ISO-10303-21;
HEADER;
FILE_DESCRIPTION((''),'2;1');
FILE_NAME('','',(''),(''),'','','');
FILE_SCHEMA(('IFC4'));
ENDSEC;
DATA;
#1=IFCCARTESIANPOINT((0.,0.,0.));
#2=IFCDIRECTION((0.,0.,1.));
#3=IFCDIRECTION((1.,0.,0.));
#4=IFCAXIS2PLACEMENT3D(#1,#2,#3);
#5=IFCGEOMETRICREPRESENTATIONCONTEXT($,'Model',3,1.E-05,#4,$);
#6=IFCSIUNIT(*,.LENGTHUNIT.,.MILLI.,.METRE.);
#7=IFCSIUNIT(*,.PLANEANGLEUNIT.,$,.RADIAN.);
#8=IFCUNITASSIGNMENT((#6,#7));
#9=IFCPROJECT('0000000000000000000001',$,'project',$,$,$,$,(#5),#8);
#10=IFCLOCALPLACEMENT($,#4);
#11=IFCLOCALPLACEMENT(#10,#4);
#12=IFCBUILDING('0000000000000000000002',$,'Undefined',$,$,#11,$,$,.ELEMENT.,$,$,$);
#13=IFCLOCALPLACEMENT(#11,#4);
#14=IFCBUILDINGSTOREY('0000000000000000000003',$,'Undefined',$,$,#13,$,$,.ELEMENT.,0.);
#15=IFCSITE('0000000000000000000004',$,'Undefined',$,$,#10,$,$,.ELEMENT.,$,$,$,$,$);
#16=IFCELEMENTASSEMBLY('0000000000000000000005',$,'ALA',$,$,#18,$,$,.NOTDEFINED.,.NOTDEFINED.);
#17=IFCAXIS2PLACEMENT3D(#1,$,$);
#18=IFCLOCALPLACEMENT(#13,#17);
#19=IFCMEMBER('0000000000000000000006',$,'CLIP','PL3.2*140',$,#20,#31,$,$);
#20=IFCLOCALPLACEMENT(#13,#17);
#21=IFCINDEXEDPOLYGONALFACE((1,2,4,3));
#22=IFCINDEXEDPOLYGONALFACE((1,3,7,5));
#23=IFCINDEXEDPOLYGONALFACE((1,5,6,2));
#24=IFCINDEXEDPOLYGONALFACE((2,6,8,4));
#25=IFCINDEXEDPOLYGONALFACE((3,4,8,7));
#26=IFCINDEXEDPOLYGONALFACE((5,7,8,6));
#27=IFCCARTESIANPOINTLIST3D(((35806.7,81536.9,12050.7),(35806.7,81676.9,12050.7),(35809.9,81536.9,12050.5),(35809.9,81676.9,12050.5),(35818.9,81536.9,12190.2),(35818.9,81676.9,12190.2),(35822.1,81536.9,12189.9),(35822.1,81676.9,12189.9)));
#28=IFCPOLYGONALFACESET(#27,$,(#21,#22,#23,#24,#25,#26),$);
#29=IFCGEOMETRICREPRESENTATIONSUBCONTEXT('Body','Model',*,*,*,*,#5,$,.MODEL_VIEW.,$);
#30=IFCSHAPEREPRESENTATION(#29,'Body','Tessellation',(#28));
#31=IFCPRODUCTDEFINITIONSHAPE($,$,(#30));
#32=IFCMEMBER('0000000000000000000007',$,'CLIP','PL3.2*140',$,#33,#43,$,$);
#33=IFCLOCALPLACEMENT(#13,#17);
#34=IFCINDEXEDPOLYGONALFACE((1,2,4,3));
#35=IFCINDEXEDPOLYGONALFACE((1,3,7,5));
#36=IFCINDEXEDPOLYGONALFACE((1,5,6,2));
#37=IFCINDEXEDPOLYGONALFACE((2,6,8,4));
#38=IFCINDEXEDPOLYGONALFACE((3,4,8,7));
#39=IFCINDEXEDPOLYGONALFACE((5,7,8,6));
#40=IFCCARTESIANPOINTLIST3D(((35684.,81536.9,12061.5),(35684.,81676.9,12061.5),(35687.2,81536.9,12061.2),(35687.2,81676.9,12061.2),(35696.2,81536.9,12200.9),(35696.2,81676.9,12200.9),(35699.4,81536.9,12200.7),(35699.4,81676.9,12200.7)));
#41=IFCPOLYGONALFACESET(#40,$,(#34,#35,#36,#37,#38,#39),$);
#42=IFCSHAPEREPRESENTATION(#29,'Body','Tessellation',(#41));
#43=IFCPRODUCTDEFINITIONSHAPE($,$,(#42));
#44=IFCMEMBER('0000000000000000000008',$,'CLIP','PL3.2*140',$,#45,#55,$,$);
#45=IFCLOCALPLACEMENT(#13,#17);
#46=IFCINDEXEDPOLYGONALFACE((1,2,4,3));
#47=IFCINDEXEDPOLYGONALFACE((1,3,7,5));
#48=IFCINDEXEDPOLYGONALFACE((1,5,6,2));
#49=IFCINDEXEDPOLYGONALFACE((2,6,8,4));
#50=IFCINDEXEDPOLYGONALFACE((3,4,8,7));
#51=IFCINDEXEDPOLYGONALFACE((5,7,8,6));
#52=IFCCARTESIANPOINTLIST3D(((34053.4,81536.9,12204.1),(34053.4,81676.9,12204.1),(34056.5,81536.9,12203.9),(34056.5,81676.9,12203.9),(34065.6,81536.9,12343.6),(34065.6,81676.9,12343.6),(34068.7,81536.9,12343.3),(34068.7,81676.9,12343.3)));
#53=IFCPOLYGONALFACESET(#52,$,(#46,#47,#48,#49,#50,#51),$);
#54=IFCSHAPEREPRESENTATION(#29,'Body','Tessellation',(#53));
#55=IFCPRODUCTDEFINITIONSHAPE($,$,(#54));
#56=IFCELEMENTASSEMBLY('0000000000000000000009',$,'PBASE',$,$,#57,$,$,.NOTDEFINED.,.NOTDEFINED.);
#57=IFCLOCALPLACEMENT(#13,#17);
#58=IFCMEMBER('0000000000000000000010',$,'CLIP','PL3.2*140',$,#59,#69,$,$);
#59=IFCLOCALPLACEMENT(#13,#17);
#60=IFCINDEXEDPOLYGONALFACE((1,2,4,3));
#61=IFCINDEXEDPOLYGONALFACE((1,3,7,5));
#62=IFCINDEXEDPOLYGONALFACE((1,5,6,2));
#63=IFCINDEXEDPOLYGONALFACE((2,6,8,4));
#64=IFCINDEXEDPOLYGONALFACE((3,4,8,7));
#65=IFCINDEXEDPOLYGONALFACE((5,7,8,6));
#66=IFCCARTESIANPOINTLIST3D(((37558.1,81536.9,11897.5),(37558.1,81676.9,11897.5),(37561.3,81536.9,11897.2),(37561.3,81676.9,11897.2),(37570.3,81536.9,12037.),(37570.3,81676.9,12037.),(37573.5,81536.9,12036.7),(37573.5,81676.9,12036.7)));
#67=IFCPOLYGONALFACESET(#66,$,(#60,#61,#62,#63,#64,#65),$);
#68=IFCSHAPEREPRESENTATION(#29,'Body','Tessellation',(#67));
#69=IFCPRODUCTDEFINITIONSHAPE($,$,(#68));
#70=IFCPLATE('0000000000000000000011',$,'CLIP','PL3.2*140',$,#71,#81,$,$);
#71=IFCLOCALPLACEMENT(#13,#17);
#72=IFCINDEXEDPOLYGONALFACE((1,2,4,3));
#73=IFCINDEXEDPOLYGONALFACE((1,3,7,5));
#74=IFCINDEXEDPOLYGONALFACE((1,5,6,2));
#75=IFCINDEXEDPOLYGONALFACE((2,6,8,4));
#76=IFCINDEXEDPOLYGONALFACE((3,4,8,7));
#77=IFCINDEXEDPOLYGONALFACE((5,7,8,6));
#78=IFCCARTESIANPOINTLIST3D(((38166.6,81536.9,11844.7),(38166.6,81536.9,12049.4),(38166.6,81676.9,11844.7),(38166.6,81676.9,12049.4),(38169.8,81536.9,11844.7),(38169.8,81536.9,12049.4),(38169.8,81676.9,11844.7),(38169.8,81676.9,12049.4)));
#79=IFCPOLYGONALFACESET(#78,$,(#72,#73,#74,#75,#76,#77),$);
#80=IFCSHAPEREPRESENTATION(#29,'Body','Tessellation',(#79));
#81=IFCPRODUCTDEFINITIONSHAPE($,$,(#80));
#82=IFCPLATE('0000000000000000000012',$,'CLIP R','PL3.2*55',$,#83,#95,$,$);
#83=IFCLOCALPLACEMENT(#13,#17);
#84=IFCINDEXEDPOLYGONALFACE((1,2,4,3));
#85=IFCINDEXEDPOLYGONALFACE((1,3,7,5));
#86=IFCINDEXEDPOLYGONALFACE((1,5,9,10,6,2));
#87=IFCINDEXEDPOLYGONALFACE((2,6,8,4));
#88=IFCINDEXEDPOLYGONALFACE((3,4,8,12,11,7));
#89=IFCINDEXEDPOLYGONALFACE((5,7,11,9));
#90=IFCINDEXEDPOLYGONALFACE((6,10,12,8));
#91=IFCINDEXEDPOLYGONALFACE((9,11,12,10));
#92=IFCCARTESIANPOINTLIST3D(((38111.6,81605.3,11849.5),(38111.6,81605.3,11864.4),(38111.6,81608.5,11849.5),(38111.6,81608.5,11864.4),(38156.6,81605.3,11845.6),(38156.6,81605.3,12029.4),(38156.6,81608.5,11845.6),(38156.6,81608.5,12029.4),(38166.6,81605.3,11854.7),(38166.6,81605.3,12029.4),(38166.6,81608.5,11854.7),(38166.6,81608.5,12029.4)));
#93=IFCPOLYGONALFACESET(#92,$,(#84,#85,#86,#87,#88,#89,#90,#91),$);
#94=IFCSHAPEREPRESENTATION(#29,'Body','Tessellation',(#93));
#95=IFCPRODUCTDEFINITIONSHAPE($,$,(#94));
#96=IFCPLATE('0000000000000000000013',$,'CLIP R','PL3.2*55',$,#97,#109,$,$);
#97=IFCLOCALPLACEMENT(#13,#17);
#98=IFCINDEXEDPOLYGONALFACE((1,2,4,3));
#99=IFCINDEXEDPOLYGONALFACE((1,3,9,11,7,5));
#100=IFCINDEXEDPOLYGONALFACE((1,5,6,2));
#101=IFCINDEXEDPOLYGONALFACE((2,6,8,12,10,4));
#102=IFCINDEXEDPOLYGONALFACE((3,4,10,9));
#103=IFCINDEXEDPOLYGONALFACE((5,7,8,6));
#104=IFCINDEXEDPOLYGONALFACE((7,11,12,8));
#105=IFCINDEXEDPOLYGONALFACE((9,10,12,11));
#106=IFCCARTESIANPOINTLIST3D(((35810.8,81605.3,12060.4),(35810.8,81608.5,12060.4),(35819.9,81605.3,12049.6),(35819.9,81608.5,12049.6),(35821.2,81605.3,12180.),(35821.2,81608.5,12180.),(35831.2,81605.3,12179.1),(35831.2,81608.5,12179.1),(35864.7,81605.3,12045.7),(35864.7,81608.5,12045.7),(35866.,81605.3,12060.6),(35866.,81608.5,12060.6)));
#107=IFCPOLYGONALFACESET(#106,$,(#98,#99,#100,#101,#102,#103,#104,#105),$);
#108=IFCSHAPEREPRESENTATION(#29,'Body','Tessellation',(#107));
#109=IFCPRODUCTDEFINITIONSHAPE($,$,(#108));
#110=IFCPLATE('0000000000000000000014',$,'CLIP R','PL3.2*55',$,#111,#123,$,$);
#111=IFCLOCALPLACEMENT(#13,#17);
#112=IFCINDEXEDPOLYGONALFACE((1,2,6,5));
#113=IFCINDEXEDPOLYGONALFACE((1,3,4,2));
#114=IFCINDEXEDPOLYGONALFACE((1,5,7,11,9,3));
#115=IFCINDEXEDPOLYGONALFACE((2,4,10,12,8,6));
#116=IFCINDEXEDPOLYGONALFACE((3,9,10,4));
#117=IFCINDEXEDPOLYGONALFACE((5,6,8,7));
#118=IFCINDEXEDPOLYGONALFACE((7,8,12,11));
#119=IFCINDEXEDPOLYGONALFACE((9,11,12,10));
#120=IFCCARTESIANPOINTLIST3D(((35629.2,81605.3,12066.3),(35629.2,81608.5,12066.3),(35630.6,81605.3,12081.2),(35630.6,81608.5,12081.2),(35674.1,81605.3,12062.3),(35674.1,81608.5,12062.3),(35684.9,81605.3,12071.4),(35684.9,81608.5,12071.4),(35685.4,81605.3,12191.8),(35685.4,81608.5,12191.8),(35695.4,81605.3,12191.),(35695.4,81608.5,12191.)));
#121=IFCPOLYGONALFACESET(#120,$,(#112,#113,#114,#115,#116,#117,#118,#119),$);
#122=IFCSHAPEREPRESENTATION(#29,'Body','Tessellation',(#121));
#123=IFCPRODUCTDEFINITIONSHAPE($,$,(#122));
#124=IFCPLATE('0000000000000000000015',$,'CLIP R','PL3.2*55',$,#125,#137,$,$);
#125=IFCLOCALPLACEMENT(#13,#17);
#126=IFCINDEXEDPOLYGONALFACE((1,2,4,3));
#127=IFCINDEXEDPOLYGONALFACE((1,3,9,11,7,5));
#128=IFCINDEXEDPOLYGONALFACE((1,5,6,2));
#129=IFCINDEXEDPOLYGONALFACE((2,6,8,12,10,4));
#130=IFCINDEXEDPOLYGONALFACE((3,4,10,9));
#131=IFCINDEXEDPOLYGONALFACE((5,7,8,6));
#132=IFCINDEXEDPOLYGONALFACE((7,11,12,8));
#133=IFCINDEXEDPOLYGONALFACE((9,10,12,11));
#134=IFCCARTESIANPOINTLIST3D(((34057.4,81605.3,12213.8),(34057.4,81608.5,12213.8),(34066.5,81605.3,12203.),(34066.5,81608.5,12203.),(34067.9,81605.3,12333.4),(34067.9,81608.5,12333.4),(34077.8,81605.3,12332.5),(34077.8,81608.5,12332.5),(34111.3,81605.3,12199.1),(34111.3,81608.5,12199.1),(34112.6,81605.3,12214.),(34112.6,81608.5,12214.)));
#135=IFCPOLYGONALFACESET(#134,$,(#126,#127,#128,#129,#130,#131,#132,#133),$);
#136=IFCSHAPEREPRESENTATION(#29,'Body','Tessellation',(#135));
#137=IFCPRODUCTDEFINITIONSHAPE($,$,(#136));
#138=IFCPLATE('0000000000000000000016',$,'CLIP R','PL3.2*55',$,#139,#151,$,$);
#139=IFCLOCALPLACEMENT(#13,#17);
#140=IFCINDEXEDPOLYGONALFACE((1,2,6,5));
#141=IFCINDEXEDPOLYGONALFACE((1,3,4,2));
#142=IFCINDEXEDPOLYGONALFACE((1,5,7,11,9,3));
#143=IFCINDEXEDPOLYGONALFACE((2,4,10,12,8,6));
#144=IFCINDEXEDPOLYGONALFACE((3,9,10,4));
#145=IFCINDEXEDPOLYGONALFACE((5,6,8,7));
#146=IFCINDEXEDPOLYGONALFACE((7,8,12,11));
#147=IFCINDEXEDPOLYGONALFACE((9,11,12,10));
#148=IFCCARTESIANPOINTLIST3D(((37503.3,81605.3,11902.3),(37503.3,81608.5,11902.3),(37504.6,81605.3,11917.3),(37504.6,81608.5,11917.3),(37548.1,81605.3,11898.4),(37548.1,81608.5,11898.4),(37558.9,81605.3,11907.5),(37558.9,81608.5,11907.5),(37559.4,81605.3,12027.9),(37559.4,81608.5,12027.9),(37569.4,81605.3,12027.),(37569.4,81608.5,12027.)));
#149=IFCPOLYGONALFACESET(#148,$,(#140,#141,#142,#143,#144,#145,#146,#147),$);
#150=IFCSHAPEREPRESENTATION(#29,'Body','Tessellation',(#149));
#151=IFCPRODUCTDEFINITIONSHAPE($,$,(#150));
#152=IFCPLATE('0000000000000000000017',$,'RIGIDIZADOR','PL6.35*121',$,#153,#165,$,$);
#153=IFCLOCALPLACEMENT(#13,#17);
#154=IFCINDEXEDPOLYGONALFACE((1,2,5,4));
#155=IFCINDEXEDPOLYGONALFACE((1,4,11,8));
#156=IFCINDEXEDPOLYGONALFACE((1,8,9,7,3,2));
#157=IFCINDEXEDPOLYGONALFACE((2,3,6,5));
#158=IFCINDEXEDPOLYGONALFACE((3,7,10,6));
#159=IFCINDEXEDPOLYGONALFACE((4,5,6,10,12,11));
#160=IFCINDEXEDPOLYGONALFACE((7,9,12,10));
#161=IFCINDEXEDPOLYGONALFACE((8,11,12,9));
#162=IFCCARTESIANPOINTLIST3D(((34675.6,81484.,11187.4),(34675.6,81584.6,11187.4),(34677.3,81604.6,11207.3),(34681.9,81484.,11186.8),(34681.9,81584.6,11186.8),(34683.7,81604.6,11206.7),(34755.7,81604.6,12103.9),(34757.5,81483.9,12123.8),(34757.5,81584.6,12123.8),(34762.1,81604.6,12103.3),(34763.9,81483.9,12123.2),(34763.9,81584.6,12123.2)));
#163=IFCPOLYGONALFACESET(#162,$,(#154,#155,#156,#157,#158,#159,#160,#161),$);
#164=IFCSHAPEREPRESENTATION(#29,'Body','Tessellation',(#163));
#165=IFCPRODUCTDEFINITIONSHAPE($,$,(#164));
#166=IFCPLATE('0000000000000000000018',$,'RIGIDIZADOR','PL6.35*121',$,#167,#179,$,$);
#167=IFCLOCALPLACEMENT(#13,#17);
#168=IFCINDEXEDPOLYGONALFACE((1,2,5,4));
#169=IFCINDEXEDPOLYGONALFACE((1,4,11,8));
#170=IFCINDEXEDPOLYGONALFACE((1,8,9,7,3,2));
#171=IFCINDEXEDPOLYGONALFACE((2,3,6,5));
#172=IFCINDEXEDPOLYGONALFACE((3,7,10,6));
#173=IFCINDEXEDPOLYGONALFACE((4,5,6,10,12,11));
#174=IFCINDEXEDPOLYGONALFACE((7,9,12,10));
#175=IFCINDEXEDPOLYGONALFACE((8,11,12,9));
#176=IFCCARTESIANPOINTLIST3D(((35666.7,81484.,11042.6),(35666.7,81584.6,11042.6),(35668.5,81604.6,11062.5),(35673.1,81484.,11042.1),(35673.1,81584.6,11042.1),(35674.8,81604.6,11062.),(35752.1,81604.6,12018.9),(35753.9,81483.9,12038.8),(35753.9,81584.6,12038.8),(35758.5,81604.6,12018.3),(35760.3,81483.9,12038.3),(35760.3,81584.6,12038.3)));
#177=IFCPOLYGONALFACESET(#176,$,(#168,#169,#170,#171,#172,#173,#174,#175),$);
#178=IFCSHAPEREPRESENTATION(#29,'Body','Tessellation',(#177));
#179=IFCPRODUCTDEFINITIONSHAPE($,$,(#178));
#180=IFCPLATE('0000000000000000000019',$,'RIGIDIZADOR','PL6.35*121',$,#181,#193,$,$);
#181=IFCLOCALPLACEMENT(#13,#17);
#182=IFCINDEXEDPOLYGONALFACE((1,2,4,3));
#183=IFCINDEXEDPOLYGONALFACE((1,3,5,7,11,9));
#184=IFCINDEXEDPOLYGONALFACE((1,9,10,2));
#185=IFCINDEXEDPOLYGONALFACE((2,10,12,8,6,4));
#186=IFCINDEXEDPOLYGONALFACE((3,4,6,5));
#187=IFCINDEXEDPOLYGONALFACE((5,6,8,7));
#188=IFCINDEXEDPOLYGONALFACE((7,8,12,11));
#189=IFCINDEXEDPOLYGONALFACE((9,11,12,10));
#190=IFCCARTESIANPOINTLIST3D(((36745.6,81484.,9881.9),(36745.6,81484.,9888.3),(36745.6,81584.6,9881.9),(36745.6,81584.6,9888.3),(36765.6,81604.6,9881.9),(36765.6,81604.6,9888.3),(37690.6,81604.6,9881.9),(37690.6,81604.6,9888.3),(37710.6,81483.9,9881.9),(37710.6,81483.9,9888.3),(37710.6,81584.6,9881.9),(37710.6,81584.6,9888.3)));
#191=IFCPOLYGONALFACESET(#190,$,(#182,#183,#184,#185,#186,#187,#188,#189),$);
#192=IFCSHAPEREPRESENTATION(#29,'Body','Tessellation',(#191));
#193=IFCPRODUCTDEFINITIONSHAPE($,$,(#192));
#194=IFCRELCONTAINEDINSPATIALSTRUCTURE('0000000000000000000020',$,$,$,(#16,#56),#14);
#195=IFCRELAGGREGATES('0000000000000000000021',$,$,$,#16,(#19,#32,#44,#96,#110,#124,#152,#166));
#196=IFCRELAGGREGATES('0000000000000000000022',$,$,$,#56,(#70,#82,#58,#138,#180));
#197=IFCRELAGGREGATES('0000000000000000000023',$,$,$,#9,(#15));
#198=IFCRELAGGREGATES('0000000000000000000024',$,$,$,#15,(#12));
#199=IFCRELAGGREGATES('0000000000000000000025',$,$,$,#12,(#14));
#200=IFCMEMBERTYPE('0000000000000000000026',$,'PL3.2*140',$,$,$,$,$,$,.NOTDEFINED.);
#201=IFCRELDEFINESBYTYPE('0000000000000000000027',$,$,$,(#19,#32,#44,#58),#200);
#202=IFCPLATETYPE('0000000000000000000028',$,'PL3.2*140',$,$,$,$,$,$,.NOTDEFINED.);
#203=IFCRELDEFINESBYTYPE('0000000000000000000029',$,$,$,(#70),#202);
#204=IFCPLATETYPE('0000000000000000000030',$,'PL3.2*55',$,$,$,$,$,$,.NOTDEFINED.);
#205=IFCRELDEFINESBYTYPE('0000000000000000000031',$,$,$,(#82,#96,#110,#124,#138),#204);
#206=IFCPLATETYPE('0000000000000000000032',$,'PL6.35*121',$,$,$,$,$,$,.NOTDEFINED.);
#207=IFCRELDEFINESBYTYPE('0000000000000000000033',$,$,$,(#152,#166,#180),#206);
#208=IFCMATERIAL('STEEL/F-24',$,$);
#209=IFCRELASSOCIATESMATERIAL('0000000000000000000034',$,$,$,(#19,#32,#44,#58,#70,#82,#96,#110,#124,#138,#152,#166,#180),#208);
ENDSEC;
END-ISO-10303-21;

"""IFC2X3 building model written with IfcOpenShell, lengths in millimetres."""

from ifc_helpers import new_model, si_unit, frame, origin_with_axes, origin_2d_with_axis, place, context, subcontext, project, spatial, polyline, rectangle, outline, extrude, material, type_object, element, aggregate, save


model = new_model("IFC2X3")

# Units and contexts
model_context = context("Model", 3, precision=1e-05, world=origin_with_axes())
body_context = subcontext(model_context, "Body", "Model", "MODEL_VIEW")
ifc_project = project(units=[si_unit("LENGTHUNIT", "METRE", prefix="MILLI"), si_unit("PLANEANGLEUNIT", "RADIAN")], contexts=[model_context])

# Site, building, storey
site_placement = place(None, origin_with_axes())
site = spatial("IfcSite", under=ifc_project, at=site_placement, Name="Undefined", CompositionType="ELEMENT")
building_placement = place(site_placement, origin_with_axes())
building = spatial("IfcBuilding", under=site, at=building_placement, Name="Undefined", CompositionType="ELEMENT")
storey_placement = place(building_placement, origin_with_axes())
storey = spatial("IfcBuildingStorey", under=building, at=storey_placement, Name="Undefined", CompositionType="ELEMENT", Elevation=0.0)

# Element assembly, members
assembly_1_placement = place(storey_placement, origin_with_axes())
assembly_1 = element("IfcElementAssembly", 1, at=assembly_1_placement, inside=storey, Name="ALA", AssemblyPlace="NOTDEFINED", PredefinedType="NOTDEFINED")
ifc_material_1 = material(Name="STEEL/F-24")
member_type = type_object("IfcMemberType", Name="PL3.2*140", PredefinedType="NOTDEFINED")
member_1_placement = place(assembly_1_placement, frame((35820.5, 81606.9, 12190.1), z_axis=(0.0, -1.0, 0.0), x_axis=(-0.087155, 0.0, -0.996195)))
member_1 = element("IfcMember", 2, at=member_1_placement, type_object=member_type, material=ifc_material_1, Name="CLIP", Description="PL3.2*140", context=body_context, shape_type="SweptSolid", body=[
    extrude(rectangle(XDim=3.2, YDim=140.0, at=origin_2d_with_axis()), frame((140.0, 0.0, 0.0), z_axis=(-1.0, 0.0, 0.0), x_axis=(0.0, -1.0, 0.0)), (0.0, 0.0, 1.0), 140.0),
])
member_2_placement = place(assembly_1_placement, frame((35697.8, 81606.9, 12200.8), z_axis=(0.0, -1.0, 0.0), x_axis=(-0.087155, 0.0, -0.996195)))
member_2 = element("IfcMember", 3, at=member_2_placement, type_object=member_type, material=ifc_material_1, Name="CLIP", Description="PL3.2*140", context=body_context, shape_type="SweptSolid", body=[
    extrude(rectangle(XDim=3.2, YDim=140.0, at=origin_2d_with_axis()), frame((140.0, 0.0, 0.0), z_axis=(-1.0, 0.0, 0.0), x_axis=(0.0, -1.0, 0.0)), (0.0, 0.0, 1.0), 140.0),
])
member_3_placement = place(assembly_1_placement, frame((34067.2, 81606.9, 12343.5), z_axis=(0.0, -1.0, 0.0), x_axis=(-0.087155, 0.0, -0.996195)))
member_3 = element("IfcMember", 4, at=member_3_placement, type_object=member_type, material=ifc_material_1, Name="CLIP", Description="PL3.2*140", context=body_context, shape_type="SweptSolid", body=[
    extrude(rectangle(XDim=3.2, YDim=140.0, at=origin_2d_with_axis()), frame((140.0, 0.0, 0.0), z_axis=(-1.0, 0.0, 0.0), x_axis=(0.0, -1.0, 0.0)), (0.0, 0.0, 1.0), 140.0),
])

# Element assembly, member, plates
assembly_2_placement = place(storey_placement, origin_with_axes())
assembly_2 = element("IfcElementAssembly", 5, at=assembly_2_placement, inside=storey, Name="PBASE", AssemblyPlace="NOTDEFINED", PredefinedType="NOTDEFINED")
member_4_placement = place(assembly_2_placement, frame((37571.9, 81606.9, 12036.8), z_axis=(0.0, -1.0, 0.0), x_axis=(-0.087155, 0.0, -0.996195)))
member_4 = element("IfcMember", 6, at=member_4_placement, type_object=member_type, material=ifc_material_1, Name="CLIP", Description="PL3.2*140", context=body_context, shape_type="SweptSolid", body=[
    extrude(rectangle(XDim=3.2, YDim=140.0, at=origin_2d_with_axis()), frame((140.0, 0.0, 0.0), z_axis=(-1.0, 0.0, 0.0), x_axis=(0.0, -1.0, 0.0)), (0.0, 0.0, 1.0), 140.0),
])
plate_type_1 = type_object("IfcPlateType", Name="PL3.2*140", PredefinedType="NOTDEFINED")
plate_1_placement = place(assembly_2_placement, frame((38168.2, 81606.9, 12049.4), z_axis=(-1.0, 0.0, 0.0), x_axis=(0.0, 0.0, -1.0)))
plate_1 = element("IfcPlate", 7, at=plate_1_placement, type_object=plate_type_1, material=ifc_material_1, Name="CLIP", Description="PL3.2*140", context=body_context, shape_type="SweptSolid", body=[
    extrude(outline(polyline([(0.0, -70.0), (0.0, 70.0), (204.7, 70.0), (204.7, -70.0), (0.0, -70.0)])), frame((0.0, 0.0, -1.6), z_axis=(0.0, 0.0, 1.0), x_axis=(1.0, 0.0, 0.0)), (0.0, 0.0, 1.0), 3.2),
])
plate_type_2 = type_object("IfcPlateType", Name="PL3.2*55", PredefinedType="NOTDEFINED")
plate_2_placement = place(assembly_2_placement, frame((38166.6, 81606.9, 12029.4), z_axis=(0.0, -1.0, 0.0), x_axis=(-1.0, 0.0, 0.0)))
plate_2 = element("IfcPlate", 8, at=plate_2_placement, type_object=plate_type_2, material=ifc_material_1, Name="CLIP R", Description="PL3.2*55", context=body_context, shape_type="SweptSolid", body=[
    extrude(outline(polyline([(0.0, 0.0), (10.0, 0.0), (55.0, 165.0), (55.0, 179.8), (10.0, 183.7), (0.0, 174.6), (0.0, 0.0)])), frame((0.0, 0.0, -1.6), z_axis=(0.0, 0.0, 1.0), x_axis=(1.0, 0.0, 0.0)), (0.0, 0.0, 1.0), 3.2),
])

# Plates
plate_3_placement = place(assembly_1_placement, frame((35821.2, 81606.9, 12180.0), z_axis=(0.0, 1.0, 0.0), x_axis=(0.996195, 0.0, -0.087155)))
plate_3 = element("IfcPlate", 9, at=plate_3_placement, type_object=plate_type_2, material=ifc_material_1, Name="CLIP R", Description="PL3.2*55", context=body_context, shape_type="SweptSolid", body=[
    extrude(outline(polyline([(0.0, 0.0), (10.0, 0.0), (55.0, 115.0), (55.0, 130.0), (10.0, 130.0), (0.0, 120.0), (0.0, 0.0)])), frame((0.0, 0.0, -1.6), z_axis=(0.0, 0.0, 1.0), x_axis=(1.0, 0.0, 0.0)), (0.0, 0.0, 1.0), 3.2),
])
plate_4_placement = place(assembly_1_placement, frame((35695.4, 81606.9, 12191.0), z_axis=(0.0, -1.0, 0.0), x_axis=(-0.996195, 0.0, 0.087155)))
plate_4 = element("IfcPlate", 10, at=plate_4_placement, type_object=plate_type_2, material=ifc_material_1, Name="CLIP R", Description="PL3.2*55", context=body_context, shape_type="SweptSolid", body=[
    extrude(outline(polyline([(0.0, 0.0), (10.0, 0.0), (55.0, 115.0), (55.0, 130.0), (10.0, 130.0), (0.0, 120.0), (0.0, 0.0)])), frame((0.0, 0.0, -1.6), z_axis=(0.0, 0.0, 1.0), x_axis=(1.0, 0.0, 0.0)), (0.0, 0.0, 1.0), 3.2),
])
plate_5_placement = place(assembly_1_placement, frame((34067.9, 81606.9, 12333.4), z_axis=(0.0, 1.0, 0.0), x_axis=(0.996195, 0.0, -0.087155)))
plate_5 = element("IfcPlate", 11, at=plate_5_placement, type_object=plate_type_2, material=ifc_material_1, Name="CLIP R", Description="PL3.2*55", context=body_context, shape_type="SweptSolid", body=[
    extrude(outline(polyline([(0.0, 0.0), (10.0, 0.0), (55.0, 115.0), (55.0, 130.0), (10.0, 130.0), (0.0, 120.0), (0.0, 0.0)])), frame((0.0, 0.0, -1.6), z_axis=(0.0, 0.0, 1.0), x_axis=(1.0, 0.0, 0.0)), (0.0, 0.0, 1.0), 3.2),
])
plate_6_placement = place(assembly_2_placement, frame((37569.4, 81606.9, 12027.0), z_axis=(0.0, -1.0, 0.0), x_axis=(-0.996195, 0.0, 0.087155)))
plate_6 = element("IfcPlate", 12, at=plate_6_placement, type_object=plate_type_2, material=ifc_material_1, Name="CLIP R", Description="PL3.2*55", context=body_context, shape_type="SweptSolid", body=[
    extrude(outline(polyline([(0.0, 0.0), (10.0, 0.0), (55.0, 115.0), (55.0, 130.0), (10.0, 130.0), (0.0, 120.0), (0.0, 0.0)])), frame((0.0, 0.0, -1.6), z_axis=(0.0, 0.0, 1.0), x_axis=(1.0, 0.0, 0.0)), (0.0, 0.0, 1.0), 3.2),
])
plate_type_3 = type_object("IfcPlateType", Name="PL6.35*121", PredefinedType="NOTDEFINED")
plate_7_placement = place(assembly_1_placement, frame((34760.7, 81604.6, 12123.5), z_axis=(0.996195, 0.0, -0.087155), x_axis=(0.0, -1.0, 0.0)))
plate_7 = element("IfcPlate", 13, at=plate_7_placement, type_object=plate_type_3, material=ifc_material_1, Name="RIGIDIZADOR", Description="PL6.35*121", context=body_context, shape_type="SweptSolid", body=[
    extrude(outline(polyline([(0.0, 20.0), (20.0, 0.0), (120.6, 0.0), (120.6, 940.0), (20.0, 940.0), (0.0, 920.0), (0.0, 20.0)])), frame((0.0, 0.0, -3.2), z_axis=(0.0, 0.0, 1.0), x_axis=(1.0, 0.0, 0.0)), (0.0, 0.0, 1.0), 6.4),
])
plate_8_placement = place(assembly_1_placement, frame((35757.1, 81604.6, 12038.5), z_axis=(0.996195, 0.0, -0.087155), x_axis=(0.0, -1.0, 0.0)))
plate_8 = element("IfcPlate", 14, at=plate_8_placement, type_object=plate_type_3, material=ifc_material_1, Name="RIGIDIZADOR", Description="PL6.35*121", context=body_context, shape_type="SweptSolid", body=[
    extrude(outline(polyline([(0.0, 20.0), (20.0, 0.0), (120.6, 0.0), (120.6, 1000.0), (20.0, 1000.0), (0.0, 980.0), (0.0, 20.0)])), frame((0.0, 0.0, -3.2), z_axis=(0.0, 0.0, 1.0), x_axis=(1.0, 0.0, 0.0)), (0.0, 0.0, 1.0), 6.4),
])
plate_9_placement = place(assembly_2_placement, frame((37710.6, 81604.6, 9885.1), z_axis=(0.0, 0.0, -1.0), x_axis=(0.0, -1.0, 0.0)))
plate_9 = element("IfcPlate", 15, at=plate_9_placement, type_object=plate_type_3, material=ifc_material_1, Name="RIGIDIZADOR", Description="PL6.35*121", context=body_context, shape_type="SweptSolid", body=[
    extrude(outline(polyline([(0.0, 20.0), (20.0, 0.0), (120.6, 0.0), (120.6, 965.0), (20.0, 965.0), (0.0, 945.0), (0.0, 20.0)])), frame((0.0, 0.0, -3.2), z_axis=(0.0, 0.0, 1.0), x_axis=(1.0, 0.0, 0.0)), (0.0, 0.0, 1.0), 6.4),
])

aggregate(assembly_1, [member_1, member_2, member_3, plate_3, plate_4, plate_5, plate_7, plate_8])

aggregate(assembly_2, [plate_1, plate_2, member_4, plate_6, plate_9])

save(model, "model.ifc")
